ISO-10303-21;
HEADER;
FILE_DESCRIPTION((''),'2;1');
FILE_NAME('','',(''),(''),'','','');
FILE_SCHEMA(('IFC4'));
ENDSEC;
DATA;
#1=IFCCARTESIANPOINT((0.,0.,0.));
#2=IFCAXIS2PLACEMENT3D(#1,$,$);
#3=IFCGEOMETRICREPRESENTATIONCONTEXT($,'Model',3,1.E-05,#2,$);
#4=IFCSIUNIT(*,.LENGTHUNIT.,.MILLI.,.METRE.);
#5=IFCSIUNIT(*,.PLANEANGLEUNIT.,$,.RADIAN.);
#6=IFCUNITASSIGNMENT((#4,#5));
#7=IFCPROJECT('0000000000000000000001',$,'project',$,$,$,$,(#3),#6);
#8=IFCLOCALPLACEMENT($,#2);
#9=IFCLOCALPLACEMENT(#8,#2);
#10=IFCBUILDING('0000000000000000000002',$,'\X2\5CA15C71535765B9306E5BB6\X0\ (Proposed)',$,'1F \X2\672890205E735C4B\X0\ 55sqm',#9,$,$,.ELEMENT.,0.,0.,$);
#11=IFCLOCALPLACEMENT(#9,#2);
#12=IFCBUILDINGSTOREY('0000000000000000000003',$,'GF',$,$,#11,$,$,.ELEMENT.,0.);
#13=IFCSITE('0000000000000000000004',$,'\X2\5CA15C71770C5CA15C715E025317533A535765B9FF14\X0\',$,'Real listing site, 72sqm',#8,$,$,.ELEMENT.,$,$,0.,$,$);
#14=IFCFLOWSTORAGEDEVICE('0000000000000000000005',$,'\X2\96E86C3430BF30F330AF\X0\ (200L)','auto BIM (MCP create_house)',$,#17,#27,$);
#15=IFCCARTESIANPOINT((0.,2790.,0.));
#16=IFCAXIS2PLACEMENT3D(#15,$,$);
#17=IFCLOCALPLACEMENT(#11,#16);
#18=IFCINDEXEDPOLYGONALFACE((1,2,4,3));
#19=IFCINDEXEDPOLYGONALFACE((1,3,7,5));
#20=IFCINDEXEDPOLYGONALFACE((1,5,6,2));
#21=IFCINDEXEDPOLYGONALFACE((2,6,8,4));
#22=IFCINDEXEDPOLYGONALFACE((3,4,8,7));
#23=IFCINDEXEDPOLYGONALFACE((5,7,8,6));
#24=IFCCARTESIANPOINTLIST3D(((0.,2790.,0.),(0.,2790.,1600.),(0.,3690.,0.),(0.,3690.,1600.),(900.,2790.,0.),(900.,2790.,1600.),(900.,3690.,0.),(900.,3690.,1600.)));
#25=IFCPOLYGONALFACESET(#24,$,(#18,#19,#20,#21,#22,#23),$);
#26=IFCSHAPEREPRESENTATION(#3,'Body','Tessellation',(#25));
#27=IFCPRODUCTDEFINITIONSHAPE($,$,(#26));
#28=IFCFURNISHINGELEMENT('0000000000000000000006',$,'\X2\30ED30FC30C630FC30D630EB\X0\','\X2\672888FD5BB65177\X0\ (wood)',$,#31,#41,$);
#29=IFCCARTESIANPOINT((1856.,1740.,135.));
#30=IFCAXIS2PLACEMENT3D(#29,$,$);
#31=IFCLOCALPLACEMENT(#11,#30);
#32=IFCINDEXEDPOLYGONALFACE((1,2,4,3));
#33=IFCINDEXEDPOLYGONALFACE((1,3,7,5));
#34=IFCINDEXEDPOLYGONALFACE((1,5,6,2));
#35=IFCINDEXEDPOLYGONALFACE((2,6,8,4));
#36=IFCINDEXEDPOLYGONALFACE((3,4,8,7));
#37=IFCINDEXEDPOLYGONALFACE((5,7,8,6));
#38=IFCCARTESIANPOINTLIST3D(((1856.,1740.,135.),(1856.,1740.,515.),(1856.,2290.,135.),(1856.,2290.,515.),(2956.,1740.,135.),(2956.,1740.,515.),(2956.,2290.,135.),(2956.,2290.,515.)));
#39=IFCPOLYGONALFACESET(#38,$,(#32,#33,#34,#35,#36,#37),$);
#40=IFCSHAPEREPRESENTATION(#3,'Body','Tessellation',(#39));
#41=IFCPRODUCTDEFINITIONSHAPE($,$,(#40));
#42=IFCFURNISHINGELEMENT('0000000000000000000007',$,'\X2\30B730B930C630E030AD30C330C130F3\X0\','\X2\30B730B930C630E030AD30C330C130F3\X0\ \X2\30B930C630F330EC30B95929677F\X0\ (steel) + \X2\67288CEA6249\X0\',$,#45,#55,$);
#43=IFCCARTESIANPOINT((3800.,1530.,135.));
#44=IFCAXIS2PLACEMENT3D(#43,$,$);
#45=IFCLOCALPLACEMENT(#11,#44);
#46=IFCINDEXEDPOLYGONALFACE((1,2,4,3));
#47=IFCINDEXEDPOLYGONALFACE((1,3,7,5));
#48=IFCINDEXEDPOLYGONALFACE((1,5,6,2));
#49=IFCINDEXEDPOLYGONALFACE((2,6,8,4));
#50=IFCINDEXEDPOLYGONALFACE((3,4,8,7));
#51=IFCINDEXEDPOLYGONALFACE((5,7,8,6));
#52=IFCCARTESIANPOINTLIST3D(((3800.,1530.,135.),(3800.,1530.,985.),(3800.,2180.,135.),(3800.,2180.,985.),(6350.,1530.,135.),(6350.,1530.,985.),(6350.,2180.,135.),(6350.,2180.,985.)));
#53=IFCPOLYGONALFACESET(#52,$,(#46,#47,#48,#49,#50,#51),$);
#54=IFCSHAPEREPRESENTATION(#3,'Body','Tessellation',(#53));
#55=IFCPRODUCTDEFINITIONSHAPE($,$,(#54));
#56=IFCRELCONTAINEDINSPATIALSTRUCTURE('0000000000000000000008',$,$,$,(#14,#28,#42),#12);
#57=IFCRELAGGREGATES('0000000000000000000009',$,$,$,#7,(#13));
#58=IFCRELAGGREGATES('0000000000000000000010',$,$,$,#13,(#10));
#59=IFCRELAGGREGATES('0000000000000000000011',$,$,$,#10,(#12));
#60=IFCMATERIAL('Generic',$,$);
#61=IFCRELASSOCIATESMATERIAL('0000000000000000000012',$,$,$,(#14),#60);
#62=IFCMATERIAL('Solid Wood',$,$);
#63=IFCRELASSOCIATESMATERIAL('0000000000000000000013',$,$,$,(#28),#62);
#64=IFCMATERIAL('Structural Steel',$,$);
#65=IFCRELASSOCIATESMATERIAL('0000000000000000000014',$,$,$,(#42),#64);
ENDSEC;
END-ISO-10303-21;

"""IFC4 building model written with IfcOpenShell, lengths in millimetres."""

from ifc_helpers import new_model, si_unit, frame, frame_2d, origin, place, context, project, spatial, rectangle, extrude, material, element, save


model = new_model("IFC4")

# Units and contexts
model_context = context("Model", 3, precision=1e-05, world=origin())
ifc_project = project(units=[si_unit("LENGTHUNIT", "METRE", prefix="MILLI"), si_unit("PLANEANGLEUNIT", "RADIAN")], contexts=[model_context])

# Site, building, storey
site_placement = place(None, origin())
site = spatial("IfcSite", under=ifc_project, at=site_placement, Name="岡山県岡山市北区南方４", ObjectType="Real listing site, 72sqm", CompositionType="ELEMENT", RefElevation=0.0)
building_placement = place(site_placement, origin())
building = spatial("IfcBuilding", under=site, at=building_placement, Name="岡山南方の家 (Proposed)", ObjectType="1F 木造平屋 55sqm", CompositionType="ELEMENT", ElevationOfRefHeight=0.0, ElevationOfTerrain=0.0)
storey_placement = place(building_placement, origin())
storey = spatial("IfcBuildingStorey", under=building, at=storey_placement, Name="GF", CompositionType="ELEMENT", Elevation=0.0)

# Shared definitions
ifc_material_1 = material(Name="Solid Wood")

# Shared definitions
ifc_material_2 = material(Name="Generic")

# Flow storage device
flow_storage_device_placement = place(storey_placement, frame((0.0, 2790.0, 0.0)))
element("IfcFlowStorageDevice", 1, at=flow_storage_device_placement, inside=storey, material=ifc_material_2, Name="雨水タンク (200L)", Description="auto BIM (MCP create_house)", context=model_context, shape_type="SweptSolid", body=[
    extrude(rectangle(XDim=900.0, YDim=900.0, at=frame_2d((450.0, 450.0))), frame((0.0, 2790.0, 0.0)), (0.0, 0.0, 1.0), 1600.0),
])

# Furnishing elements
furnishing_1_placement = place(storey_placement, frame((1856.0, 1740.0, 135.0)))
element("IfcFurnishingElement", 2, at=furnishing_1_placement, inside=storey, material=ifc_material_1, Name="ローテーブル", Description="木製家具 (wood)", context=model_context, shape_type="SweptSolid", body=[
    extrude(rectangle(XDim=1100.0, YDim=550.0, at=frame_2d((550.0, 275.0))), frame((1856.0, 1740.0, 135.0)), (0.0, 0.0, 1.0), 380.0),
])
ifc_material_3 = material(Name="Structural Steel")
furnishing_2_placement = place(storey_placement, frame((3800.0, 1530.0, 135.0)))
element("IfcFurnishingElement", 3, at=furnishing_2_placement, inside=storey, material=ifc_material_3, Name="システムキッチン", Description="システムキッチン ステンレス天板 (steel) + 木質扉", context=model_context, shape_type="SweptSolid", body=[
    extrude(rectangle(XDim=2550.0, YDim=650.0, at=frame_2d((1275.0, 325.0))), frame((3800.0, 1530.0, 135.0)), (0.0, 0.0, 1.0), 850.0),
])

save(model, "model.ifc")
